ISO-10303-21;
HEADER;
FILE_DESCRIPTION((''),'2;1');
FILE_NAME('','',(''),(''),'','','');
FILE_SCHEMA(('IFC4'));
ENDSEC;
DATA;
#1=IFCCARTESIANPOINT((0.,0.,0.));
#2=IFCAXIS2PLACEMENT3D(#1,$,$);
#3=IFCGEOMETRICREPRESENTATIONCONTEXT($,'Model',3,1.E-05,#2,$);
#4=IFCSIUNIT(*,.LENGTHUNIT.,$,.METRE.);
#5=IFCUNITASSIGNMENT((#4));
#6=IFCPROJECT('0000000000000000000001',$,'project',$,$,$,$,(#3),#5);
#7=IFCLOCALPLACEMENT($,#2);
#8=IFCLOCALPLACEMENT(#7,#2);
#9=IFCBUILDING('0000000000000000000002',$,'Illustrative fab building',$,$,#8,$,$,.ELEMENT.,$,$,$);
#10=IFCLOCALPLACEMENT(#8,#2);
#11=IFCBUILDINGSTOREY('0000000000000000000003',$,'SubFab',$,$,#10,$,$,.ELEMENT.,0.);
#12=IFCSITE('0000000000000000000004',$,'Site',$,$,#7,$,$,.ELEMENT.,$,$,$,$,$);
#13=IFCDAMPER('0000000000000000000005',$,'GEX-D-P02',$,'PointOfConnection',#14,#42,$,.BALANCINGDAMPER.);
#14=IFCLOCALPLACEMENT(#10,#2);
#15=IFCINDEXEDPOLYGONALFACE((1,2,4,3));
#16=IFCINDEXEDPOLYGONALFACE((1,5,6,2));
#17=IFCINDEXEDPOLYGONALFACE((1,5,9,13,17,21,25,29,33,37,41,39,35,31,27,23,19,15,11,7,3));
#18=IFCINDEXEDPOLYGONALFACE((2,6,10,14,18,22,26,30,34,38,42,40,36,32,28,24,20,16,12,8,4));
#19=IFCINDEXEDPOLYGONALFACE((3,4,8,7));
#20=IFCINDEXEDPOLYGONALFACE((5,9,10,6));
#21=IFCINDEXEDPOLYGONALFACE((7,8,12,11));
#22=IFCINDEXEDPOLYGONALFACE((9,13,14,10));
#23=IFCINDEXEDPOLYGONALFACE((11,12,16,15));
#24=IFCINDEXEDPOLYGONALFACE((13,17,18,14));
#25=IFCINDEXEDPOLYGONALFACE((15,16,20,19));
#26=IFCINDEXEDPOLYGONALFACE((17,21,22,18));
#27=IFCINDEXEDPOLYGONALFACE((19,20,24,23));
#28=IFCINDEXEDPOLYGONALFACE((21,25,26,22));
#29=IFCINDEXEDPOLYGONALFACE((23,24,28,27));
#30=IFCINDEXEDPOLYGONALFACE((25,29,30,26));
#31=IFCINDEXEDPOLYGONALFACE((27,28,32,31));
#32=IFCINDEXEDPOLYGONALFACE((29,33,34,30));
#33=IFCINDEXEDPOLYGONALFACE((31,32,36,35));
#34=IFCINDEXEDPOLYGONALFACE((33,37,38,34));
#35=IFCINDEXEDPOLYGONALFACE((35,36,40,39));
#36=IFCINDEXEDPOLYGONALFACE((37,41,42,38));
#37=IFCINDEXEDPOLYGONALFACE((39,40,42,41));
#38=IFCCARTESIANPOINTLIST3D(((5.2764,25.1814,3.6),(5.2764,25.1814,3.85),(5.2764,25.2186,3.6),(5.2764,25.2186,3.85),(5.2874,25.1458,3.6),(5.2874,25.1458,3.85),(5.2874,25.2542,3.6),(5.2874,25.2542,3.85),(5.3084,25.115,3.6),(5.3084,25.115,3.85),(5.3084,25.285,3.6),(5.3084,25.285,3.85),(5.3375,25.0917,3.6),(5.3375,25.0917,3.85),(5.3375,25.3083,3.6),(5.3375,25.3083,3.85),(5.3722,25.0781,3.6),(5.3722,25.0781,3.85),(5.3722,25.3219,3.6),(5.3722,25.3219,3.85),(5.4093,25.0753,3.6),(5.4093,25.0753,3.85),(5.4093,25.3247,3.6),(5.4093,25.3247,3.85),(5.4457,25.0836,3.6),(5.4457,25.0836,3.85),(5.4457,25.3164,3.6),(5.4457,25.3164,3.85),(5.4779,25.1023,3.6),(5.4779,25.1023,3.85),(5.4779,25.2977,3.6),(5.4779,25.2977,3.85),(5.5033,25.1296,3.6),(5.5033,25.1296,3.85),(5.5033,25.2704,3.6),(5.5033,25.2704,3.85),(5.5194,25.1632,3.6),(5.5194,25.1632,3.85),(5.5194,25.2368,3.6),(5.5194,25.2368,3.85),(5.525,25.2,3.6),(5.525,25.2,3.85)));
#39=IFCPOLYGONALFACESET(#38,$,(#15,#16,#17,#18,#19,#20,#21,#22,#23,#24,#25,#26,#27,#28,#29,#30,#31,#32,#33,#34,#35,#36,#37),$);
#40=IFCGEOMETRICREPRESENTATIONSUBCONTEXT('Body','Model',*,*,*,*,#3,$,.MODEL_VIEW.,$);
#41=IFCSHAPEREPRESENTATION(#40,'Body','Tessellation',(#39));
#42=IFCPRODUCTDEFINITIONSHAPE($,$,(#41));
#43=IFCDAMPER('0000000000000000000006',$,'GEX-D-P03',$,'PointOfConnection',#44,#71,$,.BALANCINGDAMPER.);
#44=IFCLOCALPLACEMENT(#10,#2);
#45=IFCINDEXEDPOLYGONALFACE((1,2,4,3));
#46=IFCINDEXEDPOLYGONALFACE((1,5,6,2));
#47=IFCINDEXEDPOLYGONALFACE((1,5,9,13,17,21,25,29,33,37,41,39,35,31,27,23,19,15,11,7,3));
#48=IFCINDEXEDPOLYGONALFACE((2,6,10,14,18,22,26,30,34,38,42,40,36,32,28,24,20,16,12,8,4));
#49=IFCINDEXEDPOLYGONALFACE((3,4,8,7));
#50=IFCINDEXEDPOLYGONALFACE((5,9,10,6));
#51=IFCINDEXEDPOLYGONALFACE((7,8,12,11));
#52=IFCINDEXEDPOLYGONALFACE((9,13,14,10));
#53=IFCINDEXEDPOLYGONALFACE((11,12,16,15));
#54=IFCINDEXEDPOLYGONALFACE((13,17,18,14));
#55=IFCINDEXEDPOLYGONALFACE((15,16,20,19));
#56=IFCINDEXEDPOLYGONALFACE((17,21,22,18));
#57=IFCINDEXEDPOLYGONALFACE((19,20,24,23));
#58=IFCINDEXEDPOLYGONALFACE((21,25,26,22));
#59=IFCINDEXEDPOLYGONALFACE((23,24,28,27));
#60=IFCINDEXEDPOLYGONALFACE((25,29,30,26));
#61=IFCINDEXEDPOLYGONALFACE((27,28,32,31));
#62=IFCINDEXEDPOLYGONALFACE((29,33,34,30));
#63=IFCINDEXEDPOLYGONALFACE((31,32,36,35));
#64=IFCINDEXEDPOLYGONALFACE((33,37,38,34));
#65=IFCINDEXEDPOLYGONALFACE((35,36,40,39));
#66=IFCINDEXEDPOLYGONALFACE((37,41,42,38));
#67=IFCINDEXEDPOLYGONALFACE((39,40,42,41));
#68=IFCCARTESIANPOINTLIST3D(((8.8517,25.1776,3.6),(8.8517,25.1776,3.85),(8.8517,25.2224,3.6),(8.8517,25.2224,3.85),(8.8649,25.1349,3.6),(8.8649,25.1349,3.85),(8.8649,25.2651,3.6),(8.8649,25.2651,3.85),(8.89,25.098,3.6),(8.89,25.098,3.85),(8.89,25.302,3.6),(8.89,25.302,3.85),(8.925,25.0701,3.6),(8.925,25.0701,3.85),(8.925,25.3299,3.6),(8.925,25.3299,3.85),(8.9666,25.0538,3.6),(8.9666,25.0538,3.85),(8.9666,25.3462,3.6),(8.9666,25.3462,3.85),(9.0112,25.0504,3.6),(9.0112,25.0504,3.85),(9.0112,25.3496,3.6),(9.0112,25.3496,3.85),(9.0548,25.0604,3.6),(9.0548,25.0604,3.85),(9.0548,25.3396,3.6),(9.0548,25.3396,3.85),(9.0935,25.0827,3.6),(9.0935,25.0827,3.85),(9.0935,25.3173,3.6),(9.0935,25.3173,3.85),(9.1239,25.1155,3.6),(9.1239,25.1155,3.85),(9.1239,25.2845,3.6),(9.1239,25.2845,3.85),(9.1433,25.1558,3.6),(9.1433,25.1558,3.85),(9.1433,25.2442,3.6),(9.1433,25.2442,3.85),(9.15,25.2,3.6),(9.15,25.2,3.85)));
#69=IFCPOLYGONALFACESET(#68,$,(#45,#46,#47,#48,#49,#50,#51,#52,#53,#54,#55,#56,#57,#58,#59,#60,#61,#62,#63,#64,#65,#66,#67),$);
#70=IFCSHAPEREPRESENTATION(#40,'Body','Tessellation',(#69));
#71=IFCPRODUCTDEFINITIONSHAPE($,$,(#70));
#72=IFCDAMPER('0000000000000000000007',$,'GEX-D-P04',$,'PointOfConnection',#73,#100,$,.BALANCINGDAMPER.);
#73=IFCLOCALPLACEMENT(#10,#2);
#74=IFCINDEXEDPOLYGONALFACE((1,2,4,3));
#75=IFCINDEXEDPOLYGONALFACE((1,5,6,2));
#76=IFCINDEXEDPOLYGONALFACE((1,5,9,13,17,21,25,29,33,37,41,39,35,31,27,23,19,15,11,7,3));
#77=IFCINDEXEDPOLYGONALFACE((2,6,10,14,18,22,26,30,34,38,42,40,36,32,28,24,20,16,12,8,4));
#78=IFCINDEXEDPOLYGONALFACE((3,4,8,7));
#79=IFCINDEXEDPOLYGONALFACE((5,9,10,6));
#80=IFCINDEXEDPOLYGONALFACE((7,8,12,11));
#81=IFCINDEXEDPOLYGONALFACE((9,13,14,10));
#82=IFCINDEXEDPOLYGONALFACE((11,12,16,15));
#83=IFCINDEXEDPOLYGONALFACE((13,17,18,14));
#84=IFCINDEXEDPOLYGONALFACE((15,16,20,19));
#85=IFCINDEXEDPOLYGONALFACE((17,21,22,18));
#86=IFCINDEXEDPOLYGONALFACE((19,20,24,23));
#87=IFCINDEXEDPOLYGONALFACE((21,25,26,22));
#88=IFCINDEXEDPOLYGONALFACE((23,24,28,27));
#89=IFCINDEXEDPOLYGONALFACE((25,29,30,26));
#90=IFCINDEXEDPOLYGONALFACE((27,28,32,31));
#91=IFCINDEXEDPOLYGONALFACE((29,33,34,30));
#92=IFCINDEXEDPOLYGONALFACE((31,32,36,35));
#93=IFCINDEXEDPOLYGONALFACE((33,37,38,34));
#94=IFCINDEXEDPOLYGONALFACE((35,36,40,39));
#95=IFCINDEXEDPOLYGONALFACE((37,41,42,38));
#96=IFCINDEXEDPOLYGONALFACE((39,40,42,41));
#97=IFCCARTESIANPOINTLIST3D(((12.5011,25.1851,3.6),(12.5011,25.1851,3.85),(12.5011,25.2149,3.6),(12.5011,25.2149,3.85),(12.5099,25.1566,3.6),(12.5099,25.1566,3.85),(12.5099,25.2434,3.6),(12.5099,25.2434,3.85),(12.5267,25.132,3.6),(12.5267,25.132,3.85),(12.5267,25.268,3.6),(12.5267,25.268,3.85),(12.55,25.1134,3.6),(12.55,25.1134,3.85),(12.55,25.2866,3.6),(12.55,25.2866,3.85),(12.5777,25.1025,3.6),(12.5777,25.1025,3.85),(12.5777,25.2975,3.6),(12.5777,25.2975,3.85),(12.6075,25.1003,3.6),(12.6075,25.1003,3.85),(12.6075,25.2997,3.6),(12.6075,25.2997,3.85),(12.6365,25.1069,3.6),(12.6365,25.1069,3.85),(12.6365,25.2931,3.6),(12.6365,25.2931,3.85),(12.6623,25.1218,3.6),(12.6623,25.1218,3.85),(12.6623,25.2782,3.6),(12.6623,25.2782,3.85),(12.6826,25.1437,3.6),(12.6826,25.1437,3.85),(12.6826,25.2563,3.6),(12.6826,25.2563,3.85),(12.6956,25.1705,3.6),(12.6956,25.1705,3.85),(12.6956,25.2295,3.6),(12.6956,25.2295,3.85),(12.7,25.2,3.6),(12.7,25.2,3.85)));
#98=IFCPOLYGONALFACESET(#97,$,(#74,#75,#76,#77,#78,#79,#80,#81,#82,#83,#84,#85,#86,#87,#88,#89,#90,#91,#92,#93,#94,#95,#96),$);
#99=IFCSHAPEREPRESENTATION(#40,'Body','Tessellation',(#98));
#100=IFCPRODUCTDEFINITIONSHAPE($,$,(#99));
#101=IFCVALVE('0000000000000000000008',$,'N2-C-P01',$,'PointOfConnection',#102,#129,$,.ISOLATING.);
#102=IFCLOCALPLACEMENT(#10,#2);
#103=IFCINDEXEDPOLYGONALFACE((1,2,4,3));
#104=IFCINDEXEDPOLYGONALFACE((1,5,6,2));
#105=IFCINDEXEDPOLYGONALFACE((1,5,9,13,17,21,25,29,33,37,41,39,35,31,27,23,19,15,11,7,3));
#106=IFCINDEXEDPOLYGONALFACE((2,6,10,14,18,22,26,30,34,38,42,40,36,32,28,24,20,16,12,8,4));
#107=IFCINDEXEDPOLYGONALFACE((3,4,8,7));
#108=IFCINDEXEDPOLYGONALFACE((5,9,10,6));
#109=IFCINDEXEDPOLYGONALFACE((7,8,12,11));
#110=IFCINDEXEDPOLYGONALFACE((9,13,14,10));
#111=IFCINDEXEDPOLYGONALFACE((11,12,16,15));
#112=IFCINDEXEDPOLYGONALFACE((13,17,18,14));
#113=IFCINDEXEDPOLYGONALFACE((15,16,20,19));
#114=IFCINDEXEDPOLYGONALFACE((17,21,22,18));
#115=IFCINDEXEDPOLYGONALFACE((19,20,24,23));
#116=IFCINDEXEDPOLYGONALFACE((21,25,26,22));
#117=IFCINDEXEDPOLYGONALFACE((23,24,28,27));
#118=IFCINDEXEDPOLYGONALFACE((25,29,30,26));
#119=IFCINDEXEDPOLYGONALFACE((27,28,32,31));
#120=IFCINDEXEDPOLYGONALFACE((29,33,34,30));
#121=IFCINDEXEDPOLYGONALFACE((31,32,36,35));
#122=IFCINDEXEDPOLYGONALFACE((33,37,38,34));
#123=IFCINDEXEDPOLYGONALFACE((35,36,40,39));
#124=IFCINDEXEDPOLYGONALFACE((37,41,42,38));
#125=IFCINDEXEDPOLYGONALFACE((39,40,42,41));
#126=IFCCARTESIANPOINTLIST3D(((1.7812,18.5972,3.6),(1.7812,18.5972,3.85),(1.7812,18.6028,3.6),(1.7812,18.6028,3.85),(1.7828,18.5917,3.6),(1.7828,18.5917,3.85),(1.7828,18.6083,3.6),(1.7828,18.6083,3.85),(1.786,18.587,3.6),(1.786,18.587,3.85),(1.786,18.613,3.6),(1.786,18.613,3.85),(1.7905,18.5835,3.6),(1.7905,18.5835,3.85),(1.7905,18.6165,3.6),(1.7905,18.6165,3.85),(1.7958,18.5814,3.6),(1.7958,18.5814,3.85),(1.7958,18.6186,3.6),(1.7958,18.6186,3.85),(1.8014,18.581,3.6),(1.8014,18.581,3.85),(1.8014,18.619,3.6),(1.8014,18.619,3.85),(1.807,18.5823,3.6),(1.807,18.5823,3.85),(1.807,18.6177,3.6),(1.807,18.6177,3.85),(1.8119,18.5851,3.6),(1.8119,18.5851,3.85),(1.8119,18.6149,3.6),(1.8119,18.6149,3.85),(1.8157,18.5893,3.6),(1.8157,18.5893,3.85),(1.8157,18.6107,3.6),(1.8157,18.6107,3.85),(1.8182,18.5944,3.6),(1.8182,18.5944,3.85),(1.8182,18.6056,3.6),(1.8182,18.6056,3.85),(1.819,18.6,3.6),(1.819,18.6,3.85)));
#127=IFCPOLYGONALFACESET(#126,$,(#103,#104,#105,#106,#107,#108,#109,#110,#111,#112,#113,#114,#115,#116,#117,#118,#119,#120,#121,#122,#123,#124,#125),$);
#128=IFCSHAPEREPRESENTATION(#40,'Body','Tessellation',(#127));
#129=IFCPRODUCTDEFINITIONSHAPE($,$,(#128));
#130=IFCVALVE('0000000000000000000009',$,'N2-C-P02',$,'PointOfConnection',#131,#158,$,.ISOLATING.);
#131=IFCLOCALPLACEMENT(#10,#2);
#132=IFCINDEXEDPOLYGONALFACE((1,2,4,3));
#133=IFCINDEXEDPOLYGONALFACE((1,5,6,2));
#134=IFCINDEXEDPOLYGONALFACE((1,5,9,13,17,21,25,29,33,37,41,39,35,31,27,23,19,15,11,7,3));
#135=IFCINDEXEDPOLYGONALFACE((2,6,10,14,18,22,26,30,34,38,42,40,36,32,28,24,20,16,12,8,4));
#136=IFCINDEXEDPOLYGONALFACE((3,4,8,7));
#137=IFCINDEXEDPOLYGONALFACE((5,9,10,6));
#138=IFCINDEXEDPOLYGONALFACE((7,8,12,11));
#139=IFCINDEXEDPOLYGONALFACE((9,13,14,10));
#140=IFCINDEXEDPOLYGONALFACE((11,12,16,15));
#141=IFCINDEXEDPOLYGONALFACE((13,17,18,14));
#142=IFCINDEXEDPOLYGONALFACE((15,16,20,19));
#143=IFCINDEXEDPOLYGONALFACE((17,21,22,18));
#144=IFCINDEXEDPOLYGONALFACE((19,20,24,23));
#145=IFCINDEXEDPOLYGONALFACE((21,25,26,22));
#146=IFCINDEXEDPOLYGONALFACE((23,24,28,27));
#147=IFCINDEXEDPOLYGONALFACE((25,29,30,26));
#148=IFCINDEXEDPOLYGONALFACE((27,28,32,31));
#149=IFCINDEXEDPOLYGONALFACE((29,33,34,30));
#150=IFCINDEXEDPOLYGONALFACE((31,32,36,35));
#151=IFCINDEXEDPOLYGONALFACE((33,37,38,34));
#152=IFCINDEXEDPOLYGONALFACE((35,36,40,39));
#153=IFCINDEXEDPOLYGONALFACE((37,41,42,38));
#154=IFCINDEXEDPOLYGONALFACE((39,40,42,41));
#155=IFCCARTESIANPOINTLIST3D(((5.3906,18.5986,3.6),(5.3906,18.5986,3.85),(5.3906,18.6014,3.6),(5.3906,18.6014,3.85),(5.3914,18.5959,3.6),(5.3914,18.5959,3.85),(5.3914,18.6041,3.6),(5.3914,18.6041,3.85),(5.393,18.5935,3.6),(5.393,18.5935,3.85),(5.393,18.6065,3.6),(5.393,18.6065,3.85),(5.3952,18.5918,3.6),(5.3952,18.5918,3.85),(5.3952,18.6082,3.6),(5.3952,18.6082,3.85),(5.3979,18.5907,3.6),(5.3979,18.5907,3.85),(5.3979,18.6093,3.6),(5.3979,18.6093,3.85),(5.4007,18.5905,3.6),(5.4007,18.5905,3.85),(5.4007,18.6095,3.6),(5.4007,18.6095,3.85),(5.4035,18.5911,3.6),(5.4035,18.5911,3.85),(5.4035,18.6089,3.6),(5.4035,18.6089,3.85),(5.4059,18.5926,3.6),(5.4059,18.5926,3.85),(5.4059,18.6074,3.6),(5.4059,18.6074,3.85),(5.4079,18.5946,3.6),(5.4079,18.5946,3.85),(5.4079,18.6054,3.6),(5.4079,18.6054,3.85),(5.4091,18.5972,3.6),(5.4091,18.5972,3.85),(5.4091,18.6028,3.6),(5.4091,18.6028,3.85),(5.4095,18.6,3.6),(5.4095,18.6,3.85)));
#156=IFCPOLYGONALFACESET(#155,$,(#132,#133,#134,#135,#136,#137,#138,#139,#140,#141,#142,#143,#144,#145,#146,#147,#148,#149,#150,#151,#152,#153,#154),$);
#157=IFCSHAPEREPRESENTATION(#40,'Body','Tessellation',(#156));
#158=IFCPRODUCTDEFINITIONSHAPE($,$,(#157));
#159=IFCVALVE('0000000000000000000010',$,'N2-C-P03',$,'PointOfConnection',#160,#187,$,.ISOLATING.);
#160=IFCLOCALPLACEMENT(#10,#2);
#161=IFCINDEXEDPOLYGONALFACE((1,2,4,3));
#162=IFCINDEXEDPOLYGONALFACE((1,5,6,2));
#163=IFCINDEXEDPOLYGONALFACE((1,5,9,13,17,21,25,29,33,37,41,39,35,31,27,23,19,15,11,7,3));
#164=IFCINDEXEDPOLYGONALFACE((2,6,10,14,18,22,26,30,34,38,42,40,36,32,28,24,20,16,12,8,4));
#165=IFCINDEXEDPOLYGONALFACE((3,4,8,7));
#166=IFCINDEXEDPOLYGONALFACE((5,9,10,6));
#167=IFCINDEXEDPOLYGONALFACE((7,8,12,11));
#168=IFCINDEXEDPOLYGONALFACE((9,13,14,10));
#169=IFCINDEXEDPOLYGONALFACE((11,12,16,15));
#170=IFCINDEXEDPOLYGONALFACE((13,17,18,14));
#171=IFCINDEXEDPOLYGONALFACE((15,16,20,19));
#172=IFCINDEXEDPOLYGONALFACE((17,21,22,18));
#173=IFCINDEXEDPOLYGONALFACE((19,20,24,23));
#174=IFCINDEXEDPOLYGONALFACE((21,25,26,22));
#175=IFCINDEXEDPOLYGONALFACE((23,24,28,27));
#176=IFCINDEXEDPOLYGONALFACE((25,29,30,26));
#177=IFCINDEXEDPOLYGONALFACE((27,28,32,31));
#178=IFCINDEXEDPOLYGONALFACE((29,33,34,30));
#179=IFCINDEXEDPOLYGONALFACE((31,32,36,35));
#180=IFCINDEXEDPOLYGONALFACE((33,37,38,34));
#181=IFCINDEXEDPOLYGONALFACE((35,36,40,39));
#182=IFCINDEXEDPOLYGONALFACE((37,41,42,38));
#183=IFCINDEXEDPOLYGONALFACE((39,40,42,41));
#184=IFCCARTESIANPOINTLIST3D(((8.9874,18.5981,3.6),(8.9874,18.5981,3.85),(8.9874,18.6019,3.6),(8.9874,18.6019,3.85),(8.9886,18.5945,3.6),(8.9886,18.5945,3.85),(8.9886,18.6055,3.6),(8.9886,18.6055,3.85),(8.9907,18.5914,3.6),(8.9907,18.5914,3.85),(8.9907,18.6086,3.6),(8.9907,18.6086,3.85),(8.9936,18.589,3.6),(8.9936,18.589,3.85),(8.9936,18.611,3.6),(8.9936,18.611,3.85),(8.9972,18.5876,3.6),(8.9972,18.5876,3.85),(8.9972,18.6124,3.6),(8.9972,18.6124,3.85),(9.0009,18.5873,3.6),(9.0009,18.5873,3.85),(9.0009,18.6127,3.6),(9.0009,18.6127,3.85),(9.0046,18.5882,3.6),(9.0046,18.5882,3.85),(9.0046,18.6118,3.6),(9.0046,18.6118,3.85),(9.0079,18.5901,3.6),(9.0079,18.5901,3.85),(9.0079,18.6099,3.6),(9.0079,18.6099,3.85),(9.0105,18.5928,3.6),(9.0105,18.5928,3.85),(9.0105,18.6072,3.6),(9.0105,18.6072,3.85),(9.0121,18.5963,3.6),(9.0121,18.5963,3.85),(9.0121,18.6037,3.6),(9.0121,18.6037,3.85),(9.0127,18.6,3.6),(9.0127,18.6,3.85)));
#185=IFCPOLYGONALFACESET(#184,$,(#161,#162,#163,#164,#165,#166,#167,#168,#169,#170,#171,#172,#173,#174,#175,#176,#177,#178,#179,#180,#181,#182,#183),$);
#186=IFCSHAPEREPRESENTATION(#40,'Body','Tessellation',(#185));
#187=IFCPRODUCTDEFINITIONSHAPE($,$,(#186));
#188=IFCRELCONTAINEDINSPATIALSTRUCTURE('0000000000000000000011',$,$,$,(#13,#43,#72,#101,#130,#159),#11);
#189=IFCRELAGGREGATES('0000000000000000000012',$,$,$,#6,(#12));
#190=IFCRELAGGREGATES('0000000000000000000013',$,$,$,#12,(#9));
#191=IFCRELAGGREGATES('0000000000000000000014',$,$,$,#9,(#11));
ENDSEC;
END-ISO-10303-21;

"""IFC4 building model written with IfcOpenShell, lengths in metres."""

from ifc_helpers import new_model, entity, si_unit, frame, origin, place, context, subcontext, project, spatial, element, save


model = new_model("IFC4")

# Units and contexts
model_context = context("Model", 3, precision=1e-05, world=origin())
body_context = subcontext(model_context, "Body", "Model", "MODEL_VIEW")
ifc_project = project(units=[si_unit("LENGTHUNIT", "METRE")], contexts=[model_context])

# Site, building, storey
site_placement = place(None, origin())
site = spatial("IfcSite", under=ifc_project, at=site_placement, Name="Site", CompositionType="ELEMENT")
building_placement = place(site_placement, origin())
building = spatial("IfcBuilding", under=site, at=building_placement, Name="Illustrative fab building", CompositionType="ELEMENT")
storey_placement = place(building_placement, origin())
storey = spatial("IfcBuildingStorey", under=building, at=storey_placement, Name="SubFab", CompositionType="ELEMENT", Elevation=0.0)

# Dampers
damper_1_placement = place(storey_placement, frame((5.4, 25.2, 3.6)))
element("IfcDamper", 1, at=damper_1_placement, inside=storey, Name="GEX-D-P02", ObjectType="PointOfConnection", PredefinedType="BALANCINGDAMPER", context=body_context, shape_type="AdvancedSweptSolid", body=[
    entity("IfcSweptDiskSolid", entity("IfcPolyline", [entity("IfcCartesianPoint", [0.0, 0.0, 0.0]), entity("IfcCartesianPoint", [0.0, 0.0, 0.25])]), 0.125),
])
damper_2_placement = place(storey_placement, frame((9.0, 25.2, 3.6)))
element("IfcDamper", 2, at=damper_2_placement, inside=storey, Name="GEX-D-P03", ObjectType="PointOfConnection", PredefinedType="BALANCINGDAMPER", context=body_context, shape_type="AdvancedSweptSolid", body=[
    entity("IfcSweptDiskSolid", entity("IfcPolyline", [entity("IfcCartesianPoint", [0.0, 0.0, 0.0]), entity("IfcCartesianPoint", [0.0, 0.0, 0.25])]), 0.15),
])
damper_3_placement = place(storey_placement, frame((12.6, 25.2, 3.6)))
element("IfcDamper", 3, at=damper_3_placement, inside=storey, Name="GEX-D-P04", ObjectType="PointOfConnection", PredefinedType="BALANCINGDAMPER", context=body_context, shape_type="AdvancedSweptSolid", body=[
    entity("IfcSweptDiskSolid", entity("IfcPolyline", [entity("IfcCartesianPoint", [0.0, 0.0, 0.0]), entity("IfcCartesianPoint", [0.0, 0.0, 0.25])]), 0.1),
])

# Valves
valve_1_placement = place(storey_placement, frame((1.8, 18.6, 3.6)))
element("IfcValve", 4, at=valve_1_placement, inside=storey, Name="N2-C-P01", ObjectType="PointOfConnection", PredefinedType="ISOLATING", context=body_context, shape_type="AdvancedSweptSolid", body=[
    entity("IfcSweptDiskSolid", entity("IfcPolyline", [entity("IfcCartesianPoint", [0.0, 0.0, 0.0]), entity("IfcCartesianPoint", [0.0, 0.0, 0.25])]), 0.019),
])
valve_2_placement = place(storey_placement, frame((5.4, 18.6, 3.6)))
element("IfcValve", 5, at=valve_2_placement, inside=storey, Name="N2-C-P02", ObjectType="PointOfConnection", PredefinedType="ISOLATING", context=body_context, shape_type="AdvancedSweptSolid", body=[
    entity("IfcSweptDiskSolid", entity("IfcPolyline", [entity("IfcCartesianPoint", [0.0, 0.0, 0.0]), entity("IfcCartesianPoint", [0.0, 0.0, 0.25])]), 0.0095),
])
valve_3_placement = place(storey_placement, frame((9.0, 18.6, 3.6)))
element("IfcValve", 6, at=valve_3_placement, inside=storey, Name="N2-C-P03", ObjectType="PointOfConnection", PredefinedType="ISOLATING", context=body_context, shape_type="AdvancedSweptSolid", body=[
    entity("IfcSweptDiskSolid", entity("IfcPolyline", [entity("IfcCartesianPoint", [0.0, 0.0, 0.0]), entity("IfcCartesianPoint", [0.0, 0.0, 0.25])]), 0.0127),
])

save(model, "model.ifc")
